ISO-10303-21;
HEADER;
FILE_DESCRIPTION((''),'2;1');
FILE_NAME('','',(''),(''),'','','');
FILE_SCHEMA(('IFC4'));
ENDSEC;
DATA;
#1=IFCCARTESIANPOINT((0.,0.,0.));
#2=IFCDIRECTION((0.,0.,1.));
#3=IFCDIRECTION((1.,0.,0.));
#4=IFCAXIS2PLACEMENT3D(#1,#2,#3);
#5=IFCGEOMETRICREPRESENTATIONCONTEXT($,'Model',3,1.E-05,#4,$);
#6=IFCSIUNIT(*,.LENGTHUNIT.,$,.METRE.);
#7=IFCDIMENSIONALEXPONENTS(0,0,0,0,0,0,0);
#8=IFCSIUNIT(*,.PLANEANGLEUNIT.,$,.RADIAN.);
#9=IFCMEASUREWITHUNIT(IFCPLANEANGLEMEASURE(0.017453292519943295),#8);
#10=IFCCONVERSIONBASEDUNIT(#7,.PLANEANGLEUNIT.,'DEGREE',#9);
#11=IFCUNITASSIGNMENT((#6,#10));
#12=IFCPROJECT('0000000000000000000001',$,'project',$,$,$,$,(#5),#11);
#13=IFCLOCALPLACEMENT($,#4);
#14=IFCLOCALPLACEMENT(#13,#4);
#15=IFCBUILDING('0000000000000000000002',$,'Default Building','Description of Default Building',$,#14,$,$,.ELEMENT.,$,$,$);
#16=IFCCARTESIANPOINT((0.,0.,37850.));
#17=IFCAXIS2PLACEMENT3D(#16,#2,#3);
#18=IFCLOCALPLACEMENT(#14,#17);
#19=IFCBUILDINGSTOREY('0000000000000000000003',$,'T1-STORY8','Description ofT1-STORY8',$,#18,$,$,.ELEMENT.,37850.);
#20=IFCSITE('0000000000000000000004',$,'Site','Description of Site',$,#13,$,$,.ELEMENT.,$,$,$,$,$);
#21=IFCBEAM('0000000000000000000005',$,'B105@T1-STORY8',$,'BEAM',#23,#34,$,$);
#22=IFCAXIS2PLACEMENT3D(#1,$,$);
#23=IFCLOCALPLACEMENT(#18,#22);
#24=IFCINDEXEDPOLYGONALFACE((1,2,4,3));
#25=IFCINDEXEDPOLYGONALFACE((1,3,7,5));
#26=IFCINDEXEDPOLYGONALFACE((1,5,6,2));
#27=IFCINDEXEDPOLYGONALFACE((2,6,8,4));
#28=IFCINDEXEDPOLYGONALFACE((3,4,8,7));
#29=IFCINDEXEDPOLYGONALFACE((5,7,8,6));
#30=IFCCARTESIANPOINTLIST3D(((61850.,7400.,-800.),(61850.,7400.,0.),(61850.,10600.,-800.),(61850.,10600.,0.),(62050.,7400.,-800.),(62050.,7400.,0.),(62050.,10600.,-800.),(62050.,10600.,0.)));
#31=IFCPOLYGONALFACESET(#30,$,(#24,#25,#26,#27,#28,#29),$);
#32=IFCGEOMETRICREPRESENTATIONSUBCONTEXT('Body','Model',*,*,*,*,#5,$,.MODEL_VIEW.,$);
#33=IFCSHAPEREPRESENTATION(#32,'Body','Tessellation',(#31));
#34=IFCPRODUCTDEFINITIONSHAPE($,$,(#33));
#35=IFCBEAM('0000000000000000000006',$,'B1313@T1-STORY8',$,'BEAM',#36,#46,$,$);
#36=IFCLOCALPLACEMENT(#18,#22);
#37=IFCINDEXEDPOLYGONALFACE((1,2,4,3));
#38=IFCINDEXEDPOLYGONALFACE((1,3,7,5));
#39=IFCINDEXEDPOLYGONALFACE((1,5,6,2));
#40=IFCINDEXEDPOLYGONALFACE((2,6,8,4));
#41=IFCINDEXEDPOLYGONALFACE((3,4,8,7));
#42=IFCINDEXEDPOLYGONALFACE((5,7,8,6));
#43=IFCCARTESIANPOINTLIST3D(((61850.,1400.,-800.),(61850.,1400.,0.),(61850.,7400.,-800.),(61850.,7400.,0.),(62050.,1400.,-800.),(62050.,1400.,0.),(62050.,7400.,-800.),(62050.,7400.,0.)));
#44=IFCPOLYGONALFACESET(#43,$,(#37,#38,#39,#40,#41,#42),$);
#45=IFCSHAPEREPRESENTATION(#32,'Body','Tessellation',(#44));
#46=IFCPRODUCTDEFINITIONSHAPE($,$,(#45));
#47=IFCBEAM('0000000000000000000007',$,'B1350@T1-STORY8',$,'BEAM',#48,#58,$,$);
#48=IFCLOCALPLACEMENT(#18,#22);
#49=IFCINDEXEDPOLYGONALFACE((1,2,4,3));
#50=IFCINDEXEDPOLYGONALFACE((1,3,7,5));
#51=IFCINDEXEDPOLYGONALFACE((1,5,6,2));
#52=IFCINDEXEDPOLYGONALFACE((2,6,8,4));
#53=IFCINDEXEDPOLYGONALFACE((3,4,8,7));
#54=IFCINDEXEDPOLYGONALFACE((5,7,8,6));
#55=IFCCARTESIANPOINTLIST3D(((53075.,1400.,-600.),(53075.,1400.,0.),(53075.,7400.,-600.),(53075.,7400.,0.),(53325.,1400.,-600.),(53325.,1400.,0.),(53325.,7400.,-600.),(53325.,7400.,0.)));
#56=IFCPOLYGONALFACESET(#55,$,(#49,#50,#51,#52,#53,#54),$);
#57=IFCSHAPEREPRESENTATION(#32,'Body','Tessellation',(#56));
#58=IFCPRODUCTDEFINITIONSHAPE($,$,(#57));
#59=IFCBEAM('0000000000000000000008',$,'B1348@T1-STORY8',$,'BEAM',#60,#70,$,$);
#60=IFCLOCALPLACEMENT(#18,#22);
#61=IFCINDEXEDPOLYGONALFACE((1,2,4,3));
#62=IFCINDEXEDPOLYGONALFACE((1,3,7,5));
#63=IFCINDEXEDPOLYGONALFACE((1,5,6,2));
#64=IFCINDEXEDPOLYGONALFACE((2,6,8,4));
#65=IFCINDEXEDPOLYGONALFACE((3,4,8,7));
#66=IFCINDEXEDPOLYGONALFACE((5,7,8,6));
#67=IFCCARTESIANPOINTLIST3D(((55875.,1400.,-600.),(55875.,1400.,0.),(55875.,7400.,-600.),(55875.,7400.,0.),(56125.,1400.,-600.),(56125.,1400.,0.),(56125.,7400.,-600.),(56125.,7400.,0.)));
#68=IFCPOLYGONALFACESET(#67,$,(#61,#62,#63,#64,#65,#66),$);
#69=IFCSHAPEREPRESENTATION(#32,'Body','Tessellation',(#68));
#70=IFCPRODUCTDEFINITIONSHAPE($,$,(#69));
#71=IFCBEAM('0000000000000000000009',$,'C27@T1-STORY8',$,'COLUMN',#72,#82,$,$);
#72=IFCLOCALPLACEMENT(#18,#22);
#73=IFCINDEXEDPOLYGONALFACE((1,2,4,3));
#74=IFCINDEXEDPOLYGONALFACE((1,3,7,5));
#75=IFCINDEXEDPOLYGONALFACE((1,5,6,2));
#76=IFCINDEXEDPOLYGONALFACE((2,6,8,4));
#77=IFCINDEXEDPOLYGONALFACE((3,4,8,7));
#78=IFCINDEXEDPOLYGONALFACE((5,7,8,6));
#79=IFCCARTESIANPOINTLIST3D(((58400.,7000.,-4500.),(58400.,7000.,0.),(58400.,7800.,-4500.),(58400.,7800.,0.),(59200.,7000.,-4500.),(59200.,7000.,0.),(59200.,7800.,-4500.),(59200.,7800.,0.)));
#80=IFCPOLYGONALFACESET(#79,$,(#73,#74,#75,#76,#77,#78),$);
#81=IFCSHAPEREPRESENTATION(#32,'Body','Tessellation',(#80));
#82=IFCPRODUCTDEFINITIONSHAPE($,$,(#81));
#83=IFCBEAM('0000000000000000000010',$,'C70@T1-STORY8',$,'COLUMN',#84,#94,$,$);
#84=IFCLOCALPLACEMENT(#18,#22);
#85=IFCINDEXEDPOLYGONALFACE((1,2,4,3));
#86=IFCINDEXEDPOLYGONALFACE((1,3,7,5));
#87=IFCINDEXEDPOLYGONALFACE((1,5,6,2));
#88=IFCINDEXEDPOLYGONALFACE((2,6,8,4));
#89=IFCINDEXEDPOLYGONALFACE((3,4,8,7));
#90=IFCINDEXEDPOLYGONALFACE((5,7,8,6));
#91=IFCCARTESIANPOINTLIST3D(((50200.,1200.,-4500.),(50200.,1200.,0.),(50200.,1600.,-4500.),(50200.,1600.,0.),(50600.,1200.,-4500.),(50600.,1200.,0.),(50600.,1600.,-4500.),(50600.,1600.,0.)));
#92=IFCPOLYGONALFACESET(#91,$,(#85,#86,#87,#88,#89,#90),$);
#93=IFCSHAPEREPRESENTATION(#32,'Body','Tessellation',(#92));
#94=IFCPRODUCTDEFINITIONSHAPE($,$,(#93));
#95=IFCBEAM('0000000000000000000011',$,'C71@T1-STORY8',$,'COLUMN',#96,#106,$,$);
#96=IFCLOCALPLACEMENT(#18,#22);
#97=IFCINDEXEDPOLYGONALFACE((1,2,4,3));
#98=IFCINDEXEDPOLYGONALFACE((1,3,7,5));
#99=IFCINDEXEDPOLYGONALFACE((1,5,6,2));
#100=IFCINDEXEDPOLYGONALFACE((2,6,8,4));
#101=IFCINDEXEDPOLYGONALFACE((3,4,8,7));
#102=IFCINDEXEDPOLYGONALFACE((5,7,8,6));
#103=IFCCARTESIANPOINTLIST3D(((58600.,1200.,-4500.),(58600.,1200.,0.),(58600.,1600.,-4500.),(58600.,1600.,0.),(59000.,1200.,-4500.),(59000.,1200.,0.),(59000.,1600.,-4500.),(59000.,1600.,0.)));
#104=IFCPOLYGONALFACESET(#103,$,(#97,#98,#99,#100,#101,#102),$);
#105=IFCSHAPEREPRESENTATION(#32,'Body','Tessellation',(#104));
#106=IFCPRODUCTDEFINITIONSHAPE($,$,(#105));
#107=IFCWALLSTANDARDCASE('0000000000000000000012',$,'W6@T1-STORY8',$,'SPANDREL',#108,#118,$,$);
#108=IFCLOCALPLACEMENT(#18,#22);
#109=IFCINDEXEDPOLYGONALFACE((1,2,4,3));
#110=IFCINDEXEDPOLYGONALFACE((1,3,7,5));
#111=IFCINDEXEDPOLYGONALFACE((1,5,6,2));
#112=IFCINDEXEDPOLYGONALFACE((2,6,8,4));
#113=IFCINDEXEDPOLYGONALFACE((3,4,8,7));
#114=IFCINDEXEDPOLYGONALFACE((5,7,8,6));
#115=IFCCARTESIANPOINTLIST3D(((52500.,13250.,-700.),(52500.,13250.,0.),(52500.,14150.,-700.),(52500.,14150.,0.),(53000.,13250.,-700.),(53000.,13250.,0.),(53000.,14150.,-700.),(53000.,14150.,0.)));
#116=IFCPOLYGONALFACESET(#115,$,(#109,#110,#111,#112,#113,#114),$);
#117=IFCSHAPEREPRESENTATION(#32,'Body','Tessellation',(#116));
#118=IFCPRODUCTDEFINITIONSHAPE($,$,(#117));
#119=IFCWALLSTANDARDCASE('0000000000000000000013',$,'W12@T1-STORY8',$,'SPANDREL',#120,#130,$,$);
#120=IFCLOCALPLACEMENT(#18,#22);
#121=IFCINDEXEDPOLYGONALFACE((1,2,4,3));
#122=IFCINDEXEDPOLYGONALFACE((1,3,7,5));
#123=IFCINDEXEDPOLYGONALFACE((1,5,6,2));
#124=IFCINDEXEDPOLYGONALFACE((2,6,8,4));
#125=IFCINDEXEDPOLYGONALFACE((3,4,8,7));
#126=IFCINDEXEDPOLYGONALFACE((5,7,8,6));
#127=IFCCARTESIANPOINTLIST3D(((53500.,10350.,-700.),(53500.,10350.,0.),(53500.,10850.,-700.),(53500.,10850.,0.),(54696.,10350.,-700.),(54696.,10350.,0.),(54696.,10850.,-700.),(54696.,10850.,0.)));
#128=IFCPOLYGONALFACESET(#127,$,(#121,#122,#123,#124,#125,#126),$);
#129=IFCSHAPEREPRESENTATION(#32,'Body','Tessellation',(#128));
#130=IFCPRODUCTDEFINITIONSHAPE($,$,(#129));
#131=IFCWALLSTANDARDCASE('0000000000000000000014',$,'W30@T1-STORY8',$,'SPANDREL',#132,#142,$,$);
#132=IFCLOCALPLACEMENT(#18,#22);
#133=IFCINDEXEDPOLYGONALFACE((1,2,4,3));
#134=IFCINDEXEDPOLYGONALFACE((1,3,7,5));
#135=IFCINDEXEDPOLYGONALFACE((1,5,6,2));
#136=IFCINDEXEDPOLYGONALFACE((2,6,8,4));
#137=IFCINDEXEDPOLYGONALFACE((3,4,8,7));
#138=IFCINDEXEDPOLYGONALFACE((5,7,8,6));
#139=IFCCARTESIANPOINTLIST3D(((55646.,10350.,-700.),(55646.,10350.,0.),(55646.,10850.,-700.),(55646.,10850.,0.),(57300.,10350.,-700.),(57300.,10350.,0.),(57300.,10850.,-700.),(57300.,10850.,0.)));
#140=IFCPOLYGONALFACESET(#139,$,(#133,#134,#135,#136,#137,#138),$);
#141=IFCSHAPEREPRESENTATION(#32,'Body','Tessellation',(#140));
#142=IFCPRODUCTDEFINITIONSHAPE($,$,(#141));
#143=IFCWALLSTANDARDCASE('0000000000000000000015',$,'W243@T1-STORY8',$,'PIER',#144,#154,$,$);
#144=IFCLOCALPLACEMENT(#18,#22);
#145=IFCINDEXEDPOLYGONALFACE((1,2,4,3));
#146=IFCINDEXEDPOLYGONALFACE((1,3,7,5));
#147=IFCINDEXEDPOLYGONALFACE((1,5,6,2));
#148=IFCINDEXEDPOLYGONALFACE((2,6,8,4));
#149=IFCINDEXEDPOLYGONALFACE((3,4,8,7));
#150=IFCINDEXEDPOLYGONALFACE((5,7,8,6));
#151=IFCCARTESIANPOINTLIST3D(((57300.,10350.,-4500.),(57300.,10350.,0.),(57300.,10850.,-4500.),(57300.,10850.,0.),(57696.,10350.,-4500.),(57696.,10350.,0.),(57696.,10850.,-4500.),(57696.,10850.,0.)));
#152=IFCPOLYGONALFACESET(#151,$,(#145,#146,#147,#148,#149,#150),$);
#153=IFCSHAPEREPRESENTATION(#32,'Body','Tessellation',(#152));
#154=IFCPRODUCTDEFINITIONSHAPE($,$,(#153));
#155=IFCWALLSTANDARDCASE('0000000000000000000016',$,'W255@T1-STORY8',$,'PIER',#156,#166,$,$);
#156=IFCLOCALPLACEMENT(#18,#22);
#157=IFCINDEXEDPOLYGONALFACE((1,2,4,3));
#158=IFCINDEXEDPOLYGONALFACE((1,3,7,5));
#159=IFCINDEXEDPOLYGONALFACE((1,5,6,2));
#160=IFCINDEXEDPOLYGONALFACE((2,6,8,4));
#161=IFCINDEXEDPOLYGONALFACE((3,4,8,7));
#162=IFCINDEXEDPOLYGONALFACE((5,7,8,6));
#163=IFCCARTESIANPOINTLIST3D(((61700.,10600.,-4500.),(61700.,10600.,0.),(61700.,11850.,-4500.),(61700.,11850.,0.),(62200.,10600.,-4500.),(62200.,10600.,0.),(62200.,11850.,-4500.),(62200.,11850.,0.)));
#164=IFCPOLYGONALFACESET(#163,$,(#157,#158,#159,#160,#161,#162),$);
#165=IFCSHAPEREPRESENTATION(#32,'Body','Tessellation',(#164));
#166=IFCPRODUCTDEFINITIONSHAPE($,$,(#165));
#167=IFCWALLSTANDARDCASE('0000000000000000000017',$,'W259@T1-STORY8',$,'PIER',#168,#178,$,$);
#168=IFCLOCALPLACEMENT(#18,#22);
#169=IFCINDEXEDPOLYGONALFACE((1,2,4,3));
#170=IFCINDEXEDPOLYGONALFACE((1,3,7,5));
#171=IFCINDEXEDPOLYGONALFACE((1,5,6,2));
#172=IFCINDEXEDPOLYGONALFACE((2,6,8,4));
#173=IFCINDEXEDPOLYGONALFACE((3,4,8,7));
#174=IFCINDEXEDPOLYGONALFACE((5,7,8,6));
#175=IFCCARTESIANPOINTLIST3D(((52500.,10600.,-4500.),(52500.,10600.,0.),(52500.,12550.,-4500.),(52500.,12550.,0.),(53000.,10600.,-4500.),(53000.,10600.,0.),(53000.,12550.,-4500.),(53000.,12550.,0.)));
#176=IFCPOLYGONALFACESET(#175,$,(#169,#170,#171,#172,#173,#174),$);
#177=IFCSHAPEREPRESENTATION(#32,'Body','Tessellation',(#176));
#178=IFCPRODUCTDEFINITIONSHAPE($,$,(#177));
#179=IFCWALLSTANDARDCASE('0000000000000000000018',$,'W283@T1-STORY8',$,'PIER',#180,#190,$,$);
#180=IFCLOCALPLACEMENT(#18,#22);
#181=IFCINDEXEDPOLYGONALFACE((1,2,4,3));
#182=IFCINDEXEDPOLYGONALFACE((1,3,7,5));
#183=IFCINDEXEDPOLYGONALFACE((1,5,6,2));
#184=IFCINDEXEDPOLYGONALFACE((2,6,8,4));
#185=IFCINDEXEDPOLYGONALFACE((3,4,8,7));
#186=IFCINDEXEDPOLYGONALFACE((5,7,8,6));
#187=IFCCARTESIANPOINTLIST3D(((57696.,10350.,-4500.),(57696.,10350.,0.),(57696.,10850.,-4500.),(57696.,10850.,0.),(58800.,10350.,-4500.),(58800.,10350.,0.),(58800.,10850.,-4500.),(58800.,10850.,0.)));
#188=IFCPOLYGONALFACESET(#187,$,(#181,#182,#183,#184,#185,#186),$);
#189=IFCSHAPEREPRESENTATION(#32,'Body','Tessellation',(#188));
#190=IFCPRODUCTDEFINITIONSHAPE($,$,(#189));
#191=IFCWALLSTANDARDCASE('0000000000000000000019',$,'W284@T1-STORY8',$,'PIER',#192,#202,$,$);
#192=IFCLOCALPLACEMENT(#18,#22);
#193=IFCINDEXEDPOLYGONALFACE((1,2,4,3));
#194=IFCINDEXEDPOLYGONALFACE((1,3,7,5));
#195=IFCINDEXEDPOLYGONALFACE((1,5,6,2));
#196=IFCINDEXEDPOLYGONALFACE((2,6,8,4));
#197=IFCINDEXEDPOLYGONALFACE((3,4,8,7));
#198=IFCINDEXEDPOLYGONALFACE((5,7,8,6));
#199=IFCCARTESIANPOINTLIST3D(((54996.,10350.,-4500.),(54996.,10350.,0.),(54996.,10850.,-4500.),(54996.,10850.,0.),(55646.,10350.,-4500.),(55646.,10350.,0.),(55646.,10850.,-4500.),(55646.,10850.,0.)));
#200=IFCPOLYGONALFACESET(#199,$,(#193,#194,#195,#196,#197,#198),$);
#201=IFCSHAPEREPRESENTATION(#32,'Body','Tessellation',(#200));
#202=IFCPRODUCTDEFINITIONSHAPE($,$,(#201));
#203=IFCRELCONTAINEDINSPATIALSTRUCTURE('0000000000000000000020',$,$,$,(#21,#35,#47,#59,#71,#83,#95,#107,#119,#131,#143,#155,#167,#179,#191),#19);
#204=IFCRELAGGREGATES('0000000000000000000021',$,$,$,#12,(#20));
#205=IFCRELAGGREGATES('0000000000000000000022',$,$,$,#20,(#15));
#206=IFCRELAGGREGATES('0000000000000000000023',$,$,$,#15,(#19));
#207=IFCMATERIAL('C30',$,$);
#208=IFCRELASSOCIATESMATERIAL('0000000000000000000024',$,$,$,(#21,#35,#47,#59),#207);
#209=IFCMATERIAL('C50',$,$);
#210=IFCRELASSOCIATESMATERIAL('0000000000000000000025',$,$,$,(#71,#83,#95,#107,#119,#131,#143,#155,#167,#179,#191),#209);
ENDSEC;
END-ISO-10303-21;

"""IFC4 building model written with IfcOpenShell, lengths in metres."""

from ifc_helpers import new_model, entity, si_unit, converted_unit, frame, origin_with_axes, place, context, subcontext, project, spatial, indexed_curve, rectangle, outline, extrude, material, element, save


model = new_model("IFC4")

# Units and contexts
model_context = context("Model", 3, precision=1e-05, world=origin_with_axes())
body_context = subcontext(model_context, "Body", "Model", "MODEL_VIEW")
ifc_project = project(units=[si_unit("LENGTHUNIT", "METRE"), converted_unit("PLANEANGLEUNIT", "DEGREE", entity("IfcPlaneAngleMeasure", 0.017453292519943295), si_unit("PLANEANGLEUNIT", "RADIAN"), dimensions=[0, 0, 0, 0, 0, 0, 0])], contexts=[model_context])

# Site, building, storey
site_placement = place(None, origin_with_axes())
site = spatial("IfcSite", under=ifc_project, at=site_placement, Name="Site", Description="Description of Site", CompositionType="ELEMENT")
building_placement = place(site_placement, origin_with_axes())
building = spatial("IfcBuilding", under=site, at=building_placement, Name="Default Building", Description="Description of Default Building", CompositionType="ELEMENT")
storey_placement = place(building_placement, frame((0.0, 0.0, 37850.0), z_axis=(0.0, 0.0, 1.0), x_axis=(1.0, 0.0, 0.0)))
storey = spatial("IfcBuildingStorey", under=building, at=storey_placement, Name="T1-STORY8", Description="Description ofT1-STORY8", CompositionType="ELEMENT", Elevation=37850.0)

# Beams
ifc_material_1 = material(Name="C30")
beam_1_placement = place(storey_placement, frame((61950.0, 7400.0, -400.0), z_axis=(0.0, 1.0, 0.0), x_axis=(-1.0, 0.0, 0.0)))
element("IfcBeam", 1, at=beam_1_placement, inside=storey, material=ifc_material_1, Name="B105@T1-STORY8", ObjectType="BEAM", context=body_context, shape_type="SweptSolid", body=[
    extrude(rectangle(XDim=200.0, YDim=800.0), origin_with_axes(), (0.0, 0.0, 1.0), 3200.0),
])
beam_2_placement = place(storey_placement, frame((61950.0, 1400.0, -400.0), z_axis=(0.0, 1.0, 0.0), x_axis=(-1.0, 0.0, 0.0)))
element("IfcBeam", 2, at=beam_2_placement, inside=storey, material=ifc_material_1, Name="B1313@T1-STORY8", ObjectType="BEAM", context=body_context, shape_type="SweptSolid", body=[
    extrude(rectangle(XDim=200.0, YDim=800.0), origin_with_axes(), (0.0, 0.0, 1.0), 6000.0),
])
for number, where, z_axis, x_axis, name in (
    (3, (53200.0, 1400.0, -300.0), (0.0, 1.0, 0.0), (-1.0, 0.0, 0.0), "B1350@T1-STORY8"),
    (4, (56000.0, 1400.0, -300.0), (0.0, 1.0, 0.0), (-1.0, 0.0, 0.0), "B1348@T1-STORY8"),
):
    element("IfcBeam", number, at=place(storey_placement, frame(where, z_axis=z_axis, x_axis=x_axis)), inside=storey, material=ifc_material_1, Name=name, ObjectType="BEAM", context=body_context, shape_type="SweptSolid", body=[
        extrude(rectangle(XDim=250.0, YDim=600.0), origin_with_axes(), (0.0, 0.0, 1.0), 6000.0),
    ])
ifc_material_2 = material(Name="C50")
beam_3_placement = place(storey_placement, frame((58800.0, 7400.0, -4500.0), z_axis=(0.0, 0.0, 1.0), x_axis=(-1.0, 0.0, 0.0)))
element("IfcBeam", 5, at=beam_3_placement, inside=storey, material=ifc_material_2, Name="C27@T1-STORY8", ObjectType="COLUMN", context=body_context, shape_type="SweptSolid", body=[
    extrude(rectangle(XDim=800.0, YDim=800.0), origin_with_axes(), (0.0, 0.0, 1.0), 4500.0),
])
for number, where, z_axis, x_axis, name in (
    (6, (50400.0, 1400.0, -4500.0), (0.0, 0.0, 1.0), (-1.0, 0.0, 0.0), "C70@T1-STORY8"),
    (7, (58800.0, 1400.0, -4500.0), (0.0, 0.0, 1.0), (-1.0, 0.0, 0.0), "C71@T1-STORY8"),
):
    element("IfcBeam", number, at=place(storey_placement, frame(where, z_axis=z_axis, x_axis=x_axis)), inside=storey, material=ifc_material_2, Name=name, ObjectType="COLUMN", context=body_context, shape_type="SweptSolid", body=[
        extrude(rectangle(XDim=400.0, YDim=400.0), origin_with_axes(), (0.0, 0.0, 1.0), 4500.0),
    ])

# Walls
wall_1_placement = place(storey_placement, frame((52750.0, 13250.0, -700.0), z_axis=(0.0, 0.0, 1.0), x_axis=(0.0, 1.0, 0.0)))
element("IfcWallStandardCase", 8, at=wall_1_placement, inside=storey, material=ifc_material_2, Name="W6@T1-STORY8", ObjectType="SPANDREL", context=body_context, shape_type="SweptSolid", body=[
    extrude(outline(indexed_curve([(0.0, -250.0), (0.0, 250.0), (900.0, 250.0), (900.0, -250.0), (0.0, -250.0)], self_intersect=False)), origin_with_axes(), (0.0, 0.0, 1.0), 700.0),
])
wall_2_placement = place(storey_placement, frame((53500.0, 10600.0, -700.0), z_axis=(0.0, 0.0, 1.0), x_axis=(1.0, 0.0, 0.0)))
element("IfcWallStandardCase", 9, at=wall_2_placement, inside=storey, material=ifc_material_2, Name="W12@T1-STORY8", ObjectType="SPANDREL", context=body_context, shape_type="SweptSolid", body=[
    extrude(outline(indexed_curve([(0.0, -250.0), (0.0, 250.0), (1196.0, 250.0), (1196.0, -250.0), (0.0, -250.0)], self_intersect=False)), origin_with_axes(), (0.0, 0.0, 1.0), 700.0),
])
wall_3_placement = place(storey_placement, frame((55646.0, 10600.0, -700.0), z_axis=(0.0, 0.0, 1.0), x_axis=(1.0, 0.0, 0.0)))
element("IfcWallStandardCase", 10, at=wall_3_placement, inside=storey, material=ifc_material_2, Name="W30@T1-STORY8", ObjectType="SPANDREL", context=body_context, shape_type="SweptSolid", body=[
    extrude(outline(indexed_curve([(0.0, -250.0), (0.0, 250.0), (1654.0, 250.0), (1654.0, -250.0), (0.0, -250.0)], self_intersect=False)), origin_with_axes(), (0.0, 0.0, 1.0), 700.0),
])
wall_4_placement = place(storey_placement, frame((57300.0, 10600.0, -4500.0), z_axis=(0.0, 0.0, 1.0), x_axis=(1.0, 0.0, 0.0)))
element("IfcWallStandardCase", 11, at=wall_4_placement, inside=storey, material=ifc_material_2, Name="W243@T1-STORY8", ObjectType="PIER", context=body_context, shape_type="SweptSolid", body=[
    extrude(outline(indexed_curve([(0.0, -250.0), (0.0, 250.0), (396.0, 250.0), (396.0, -250.0), (0.0, -250.0)], self_intersect=False)), origin_with_axes(), (0.0, 0.0, 1.0), 4500.0),
])
wall_5_placement = place(storey_placement, frame((61950.0, 10600.0, -4500.0), z_axis=(0.0, 0.0, 1.0), x_axis=(0.0, 1.0, 0.0)))
element("IfcWallStandardCase", 12, at=wall_5_placement, inside=storey, material=ifc_material_2, Name="W255@T1-STORY8", ObjectType="PIER", context=body_context, shape_type="SweptSolid", body=[
    extrude(outline(indexed_curve([(0.0, -250.0), (0.0, 250.0), (1250.0, 250.0), (1250.0, -250.0), (0.0, -250.0)], self_intersect=False)), origin_with_axes(), (0.0, 0.0, 1.0), 4500.0),
])
wall_6_placement = place(storey_placement, frame((52750.0, 10600.0, -4500.0), z_axis=(0.0, 0.0, 1.0), x_axis=(0.0, 1.0, 0.0)))
element("IfcWallStandardCase", 13, at=wall_6_placement, inside=storey, material=ifc_material_2, Name="W259@T1-STORY8", ObjectType="PIER", context=body_context, shape_type="SweptSolid", body=[
    extrude(outline(indexed_curve([(0.0, -250.0), (0.0, 250.0), (1950.0, 250.0), (1950.0, -250.0), (0.0, -250.0)], self_intersect=False)), origin_with_axes(), (0.0, 0.0, 1.0), 4500.0),
])
wall_7_placement = place(storey_placement, frame((57696.0, 10600.0, -4500.0), z_axis=(0.0, 0.0, 1.0), x_axis=(1.0, 0.0, 0.0)))
element("IfcWallStandardCase", 14, at=wall_7_placement, inside=storey, material=ifc_material_2, Name="W283@T1-STORY8", ObjectType="PIER", context=body_context, shape_type="SweptSolid", body=[
    extrude(outline(indexed_curve([(0.0, -250.0), (0.0, 250.0), (1104.0, 250.0), (1104.0, -250.0), (0.0, -250.0)], self_intersect=False)), origin_with_axes(), (0.0, 0.0, 1.0), 4500.0),
])
wall_8_placement = place(storey_placement, frame((54996.0, 10600.0, -4500.0), z_axis=(0.0, 0.0, 1.0), x_axis=(1.0, 0.0, 0.0)))
element("IfcWallStandardCase", 15, at=wall_8_placement, inside=storey, material=ifc_material_2, Name="W284@T1-STORY8", ObjectType="PIER", context=body_context, shape_type="SweptSolid", body=[
    extrude(outline(indexed_curve([(0.0, -250.0), (0.0, 250.0), (650.0, 250.0), (650.0, -250.0), (0.0, -250.0)], self_intersect=False)), origin_with_axes(), (0.0, 0.0, 1.0), 4500.0),
])

save(model, "model.ifc")
